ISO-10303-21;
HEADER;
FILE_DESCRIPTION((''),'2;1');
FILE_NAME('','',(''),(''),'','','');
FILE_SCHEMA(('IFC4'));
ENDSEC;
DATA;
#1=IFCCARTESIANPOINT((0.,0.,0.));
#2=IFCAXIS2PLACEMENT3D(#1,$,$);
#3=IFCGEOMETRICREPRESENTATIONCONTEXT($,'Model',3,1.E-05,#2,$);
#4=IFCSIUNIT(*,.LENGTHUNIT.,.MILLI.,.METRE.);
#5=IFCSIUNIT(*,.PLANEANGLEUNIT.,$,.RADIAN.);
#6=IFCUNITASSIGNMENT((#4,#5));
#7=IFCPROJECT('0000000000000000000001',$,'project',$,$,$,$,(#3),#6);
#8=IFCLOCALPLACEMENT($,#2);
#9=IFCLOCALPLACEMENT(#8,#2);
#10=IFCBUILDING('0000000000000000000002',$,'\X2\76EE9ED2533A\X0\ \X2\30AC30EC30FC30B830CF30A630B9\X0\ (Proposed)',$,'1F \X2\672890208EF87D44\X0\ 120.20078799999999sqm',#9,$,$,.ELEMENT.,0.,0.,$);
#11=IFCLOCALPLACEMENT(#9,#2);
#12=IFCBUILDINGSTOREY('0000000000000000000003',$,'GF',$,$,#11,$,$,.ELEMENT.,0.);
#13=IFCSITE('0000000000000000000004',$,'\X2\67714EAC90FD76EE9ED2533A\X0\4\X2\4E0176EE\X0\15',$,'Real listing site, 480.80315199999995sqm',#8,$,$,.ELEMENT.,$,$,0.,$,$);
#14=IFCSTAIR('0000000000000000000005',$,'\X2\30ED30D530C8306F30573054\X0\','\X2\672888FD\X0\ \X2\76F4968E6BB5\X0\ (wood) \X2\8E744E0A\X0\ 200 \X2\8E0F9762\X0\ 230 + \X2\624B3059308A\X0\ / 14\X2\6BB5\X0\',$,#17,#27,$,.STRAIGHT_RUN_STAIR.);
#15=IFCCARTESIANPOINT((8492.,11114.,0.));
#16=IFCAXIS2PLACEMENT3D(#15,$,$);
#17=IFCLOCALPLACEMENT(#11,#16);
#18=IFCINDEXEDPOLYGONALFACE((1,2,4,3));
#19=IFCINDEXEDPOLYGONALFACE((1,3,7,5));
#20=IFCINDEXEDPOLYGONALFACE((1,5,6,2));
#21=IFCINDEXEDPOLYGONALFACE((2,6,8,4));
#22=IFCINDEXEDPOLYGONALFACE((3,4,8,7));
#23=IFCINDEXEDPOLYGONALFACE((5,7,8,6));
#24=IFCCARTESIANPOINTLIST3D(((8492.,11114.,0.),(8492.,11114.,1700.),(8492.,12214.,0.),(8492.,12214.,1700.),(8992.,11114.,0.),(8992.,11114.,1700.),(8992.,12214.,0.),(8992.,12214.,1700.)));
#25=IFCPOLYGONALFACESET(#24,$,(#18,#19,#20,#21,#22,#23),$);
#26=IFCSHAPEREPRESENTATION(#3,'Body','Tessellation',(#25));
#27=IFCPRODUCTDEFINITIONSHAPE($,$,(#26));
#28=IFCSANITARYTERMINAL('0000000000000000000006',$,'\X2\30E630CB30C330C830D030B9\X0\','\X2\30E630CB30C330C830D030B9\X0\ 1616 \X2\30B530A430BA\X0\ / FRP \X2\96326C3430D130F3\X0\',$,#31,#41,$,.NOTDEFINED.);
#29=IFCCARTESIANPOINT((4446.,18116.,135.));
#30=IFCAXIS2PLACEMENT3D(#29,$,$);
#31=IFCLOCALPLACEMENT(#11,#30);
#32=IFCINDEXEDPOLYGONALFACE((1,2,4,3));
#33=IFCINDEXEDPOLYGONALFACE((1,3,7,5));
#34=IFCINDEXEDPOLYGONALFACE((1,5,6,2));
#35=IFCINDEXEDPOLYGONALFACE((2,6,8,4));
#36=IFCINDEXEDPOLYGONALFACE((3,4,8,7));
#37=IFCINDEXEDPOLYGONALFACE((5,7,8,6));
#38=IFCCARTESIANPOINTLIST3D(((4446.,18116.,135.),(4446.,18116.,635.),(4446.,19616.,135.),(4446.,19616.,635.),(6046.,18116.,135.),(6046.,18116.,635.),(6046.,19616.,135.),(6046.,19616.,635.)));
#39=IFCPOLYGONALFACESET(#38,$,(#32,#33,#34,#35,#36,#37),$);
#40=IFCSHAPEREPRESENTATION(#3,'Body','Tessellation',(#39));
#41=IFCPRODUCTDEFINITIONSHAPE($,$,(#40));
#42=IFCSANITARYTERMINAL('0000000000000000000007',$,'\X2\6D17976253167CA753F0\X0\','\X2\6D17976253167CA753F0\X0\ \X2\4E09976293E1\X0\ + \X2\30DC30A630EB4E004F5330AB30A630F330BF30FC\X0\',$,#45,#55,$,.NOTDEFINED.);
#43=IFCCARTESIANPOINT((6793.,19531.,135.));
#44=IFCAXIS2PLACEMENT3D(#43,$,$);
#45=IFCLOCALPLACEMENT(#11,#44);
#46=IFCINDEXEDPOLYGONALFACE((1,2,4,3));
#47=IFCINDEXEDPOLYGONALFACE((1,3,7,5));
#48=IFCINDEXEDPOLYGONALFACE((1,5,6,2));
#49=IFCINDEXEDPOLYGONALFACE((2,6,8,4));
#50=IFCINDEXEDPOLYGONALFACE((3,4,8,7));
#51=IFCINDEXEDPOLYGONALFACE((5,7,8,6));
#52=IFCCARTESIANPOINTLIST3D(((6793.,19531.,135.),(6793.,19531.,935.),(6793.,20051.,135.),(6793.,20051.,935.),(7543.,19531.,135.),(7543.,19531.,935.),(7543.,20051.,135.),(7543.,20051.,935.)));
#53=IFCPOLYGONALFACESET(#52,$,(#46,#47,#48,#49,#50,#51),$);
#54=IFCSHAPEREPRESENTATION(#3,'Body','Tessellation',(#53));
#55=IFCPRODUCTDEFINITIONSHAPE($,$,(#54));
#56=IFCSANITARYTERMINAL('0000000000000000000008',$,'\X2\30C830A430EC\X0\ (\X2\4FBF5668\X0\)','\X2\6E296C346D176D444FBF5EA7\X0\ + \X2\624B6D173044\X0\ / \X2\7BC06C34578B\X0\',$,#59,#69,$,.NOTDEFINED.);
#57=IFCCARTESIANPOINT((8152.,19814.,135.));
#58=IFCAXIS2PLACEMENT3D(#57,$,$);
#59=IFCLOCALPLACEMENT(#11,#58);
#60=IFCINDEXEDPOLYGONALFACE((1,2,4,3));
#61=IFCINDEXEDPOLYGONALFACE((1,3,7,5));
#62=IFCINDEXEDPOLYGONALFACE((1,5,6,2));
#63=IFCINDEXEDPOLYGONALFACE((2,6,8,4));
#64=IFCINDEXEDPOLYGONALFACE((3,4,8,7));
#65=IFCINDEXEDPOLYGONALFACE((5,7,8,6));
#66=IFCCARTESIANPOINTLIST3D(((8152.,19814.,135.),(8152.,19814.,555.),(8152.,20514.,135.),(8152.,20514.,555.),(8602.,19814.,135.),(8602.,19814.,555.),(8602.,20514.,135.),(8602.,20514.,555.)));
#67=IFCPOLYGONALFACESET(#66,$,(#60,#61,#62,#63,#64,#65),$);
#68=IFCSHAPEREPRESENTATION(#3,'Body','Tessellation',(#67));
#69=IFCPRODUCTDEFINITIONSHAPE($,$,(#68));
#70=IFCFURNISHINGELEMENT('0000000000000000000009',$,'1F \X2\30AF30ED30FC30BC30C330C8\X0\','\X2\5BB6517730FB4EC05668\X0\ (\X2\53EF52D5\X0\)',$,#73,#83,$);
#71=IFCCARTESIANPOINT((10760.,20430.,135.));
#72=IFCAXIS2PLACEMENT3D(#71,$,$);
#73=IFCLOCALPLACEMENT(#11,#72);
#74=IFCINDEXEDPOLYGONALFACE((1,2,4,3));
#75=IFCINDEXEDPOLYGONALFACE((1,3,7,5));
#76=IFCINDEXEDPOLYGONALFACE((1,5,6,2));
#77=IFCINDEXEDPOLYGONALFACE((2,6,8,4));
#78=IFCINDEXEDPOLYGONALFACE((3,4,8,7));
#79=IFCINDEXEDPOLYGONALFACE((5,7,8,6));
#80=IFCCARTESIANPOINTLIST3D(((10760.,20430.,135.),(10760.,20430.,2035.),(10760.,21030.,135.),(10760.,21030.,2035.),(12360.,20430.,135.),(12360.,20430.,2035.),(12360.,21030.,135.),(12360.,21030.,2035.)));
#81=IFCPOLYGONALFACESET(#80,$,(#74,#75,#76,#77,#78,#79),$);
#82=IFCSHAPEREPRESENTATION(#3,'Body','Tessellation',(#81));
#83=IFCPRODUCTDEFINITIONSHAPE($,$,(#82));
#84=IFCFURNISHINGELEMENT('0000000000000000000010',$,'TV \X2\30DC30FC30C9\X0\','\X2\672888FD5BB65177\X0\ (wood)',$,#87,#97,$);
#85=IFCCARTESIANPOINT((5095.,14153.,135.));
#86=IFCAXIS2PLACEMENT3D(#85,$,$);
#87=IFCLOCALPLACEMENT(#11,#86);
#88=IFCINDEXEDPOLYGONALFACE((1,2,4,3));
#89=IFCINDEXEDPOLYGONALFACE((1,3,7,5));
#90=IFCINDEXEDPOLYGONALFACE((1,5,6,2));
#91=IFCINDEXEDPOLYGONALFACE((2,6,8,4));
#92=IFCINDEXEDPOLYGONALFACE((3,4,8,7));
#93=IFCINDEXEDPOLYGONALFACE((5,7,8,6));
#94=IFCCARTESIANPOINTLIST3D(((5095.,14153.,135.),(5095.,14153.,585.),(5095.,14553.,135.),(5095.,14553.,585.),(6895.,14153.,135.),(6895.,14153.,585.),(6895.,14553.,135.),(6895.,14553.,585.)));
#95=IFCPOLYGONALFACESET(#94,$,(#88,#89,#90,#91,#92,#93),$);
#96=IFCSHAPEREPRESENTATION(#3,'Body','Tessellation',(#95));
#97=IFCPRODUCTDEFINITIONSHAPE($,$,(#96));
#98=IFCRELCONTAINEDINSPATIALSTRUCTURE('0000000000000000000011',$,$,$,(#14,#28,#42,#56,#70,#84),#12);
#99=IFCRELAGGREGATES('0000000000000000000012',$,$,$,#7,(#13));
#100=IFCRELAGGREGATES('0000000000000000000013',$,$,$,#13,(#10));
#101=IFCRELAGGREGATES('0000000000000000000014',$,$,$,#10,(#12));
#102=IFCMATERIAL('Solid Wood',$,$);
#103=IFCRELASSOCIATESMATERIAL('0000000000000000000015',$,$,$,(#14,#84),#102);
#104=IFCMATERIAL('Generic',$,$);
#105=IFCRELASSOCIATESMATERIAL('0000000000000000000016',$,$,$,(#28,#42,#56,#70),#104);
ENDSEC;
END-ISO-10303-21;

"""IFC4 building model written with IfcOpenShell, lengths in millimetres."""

from ifc_helpers import new_model, si_unit, frame, frame_2d, origin, place, context, project, spatial, rectangle, extrude, material, element, save


model = new_model("IFC4")

# Units and contexts
model_context = context("Model", 3, precision=1e-05, world=origin())
ifc_project = project(units=[si_unit("LENGTHUNIT", "METRE", prefix="MILLI"), si_unit("PLANEANGLEUNIT", "RADIAN")], contexts=[model_context])

# Site, building, storey
site_placement = place(None, origin())
site = spatial("IfcSite", under=ifc_project, at=site_placement, Name="東京都目黒区4丁目15", ObjectType="Real listing site, 480.80315199999995sqm", CompositionType="ELEMENT", RefElevation=0.0)
building_placement = place(site_placement, origin())
building = spatial("IfcBuilding", under=site, at=building_placement, Name="目黒区 ガレージハウス (Proposed)", ObjectType="1F 木造軸組 120.20078799999999sqm", CompositionType="ELEMENT", ElevationOfRefHeight=0.0, ElevationOfTerrain=0.0)
storey_placement = place(building_placement, origin())
storey = spatial("IfcBuildingStorey", under=building, at=storey_placement, Name="GF", CompositionType="ELEMENT", Elevation=0.0)

# Shared definitions
ifc_material_1 = material(Name="Solid Wood")

# Stair
stair_placement = place(storey_placement, frame((8492.0, 11114.0, 0.0)))
element("IfcStair", 1, at=stair_placement, inside=storey, material=ifc_material_1, Name="ロフトはしご", Description="木製 直階段 (wood) 蹴上 200 踏面 230 + 手すり / 14段", PredefinedType="STRAIGHT_RUN_STAIR", context=model_context, shape_type="SweptSolid", body=[
    extrude(rectangle(XDim=500.0, YDim=1100.0, at=frame_2d((250.0, 550.0))), frame((8492.0, 11114.0, 0.0)), (0.0, 0.0, 1.0), 1700.0),
])

# Sanitary terminals
ifc_material_2 = material(Name="Generic")
sanitary_terminal_1_placement = place(storey_placement, frame((4446.0, 18116.0, 135.0)))
element("IfcSanitaryTerminal", 2, at=sanitary_terminal_1_placement, inside=storey, material=ifc_material_2, Name="ユニットバス", Description="ユニットバス 1616 サイズ / FRP 防水パン", PredefinedType="NOTDEFINED", context=model_context, shape_type="SweptSolid", body=[
    extrude(rectangle(XDim=1600.0, YDim=1500.0, at=frame_2d((800.0, 750.0))), frame((4446.0, 18116.0, 135.0)), (0.0, 0.0, 1.0), 500.0),
])
sanitary_terminal_2_placement = place(storey_placement, frame((6793.0, 19531.0, 135.0)))
element("IfcSanitaryTerminal", 3, at=sanitary_terminal_2_placement, inside=storey, material=ifc_material_2, Name="洗面化粧台", Description="洗面化粧台 三面鏡 + ボウル一体カウンター", PredefinedType="NOTDEFINED", context=model_context, shape_type="SweptSolid", body=[
    extrude(rectangle(XDim=750.0, YDim=520.0, at=frame_2d((375.0, 260.0))), frame((6793.0, 19531.0, 135.0)), (0.0, 0.0, 1.0), 800.0),
])
sanitary_terminal_3_placement = place(storey_placement, frame((8152.0, 19814.0, 135.0)))
element("IfcSanitaryTerminal", 4, at=sanitary_terminal_3_placement, inside=storey, material=ifc_material_2, Name="トイレ (便器)", Description="温水洗浄便座 + 手洗い / 節水型", PredefinedType="NOTDEFINED", context=model_context, shape_type="SweptSolid", body=[
    extrude(rectangle(XDim=450.0, YDim=700.0, at=frame_2d((225.0, 350.0))), frame((8152.0, 19814.0, 135.0)), (0.0, 0.0, 1.0), 420.0),
])

# Furnishing elements
furnishing_1_placement = place(storey_placement, frame((10760.0, 20430.0, 135.0)))
element("IfcFurnishingElement", 5, at=furnishing_1_placement, inside=storey, material=ifc_material_2, Name="1F クローゼット", Description="家具・什器 (可動)", context=model_context, shape_type="SweptSolid", body=[
    extrude(rectangle(XDim=1600.0, YDim=600.0, at=frame_2d((800.0, 300.0))), frame((10760.0, 20430.0, 135.0)), (0.0, 0.0, 1.0), 1900.0),
])
furnishing_2_placement = place(storey_placement, frame((5095.0, 14153.0, 135.0)))
element("IfcFurnishingElement", 6, at=furnishing_2_placement, inside=storey, material=ifc_material_1, Name="TV ボード", Description="木製家具 (wood)", context=model_context, shape_type="SweptSolid", body=[
    extrude(rectangle(XDim=1800.0, YDim=400.0, at=frame_2d((900.0, 200.0))), frame((5095.0, 14153.0, 135.0)), (0.0, 0.0, 1.0), 450.0),
])

save(model, "model.ifc")
